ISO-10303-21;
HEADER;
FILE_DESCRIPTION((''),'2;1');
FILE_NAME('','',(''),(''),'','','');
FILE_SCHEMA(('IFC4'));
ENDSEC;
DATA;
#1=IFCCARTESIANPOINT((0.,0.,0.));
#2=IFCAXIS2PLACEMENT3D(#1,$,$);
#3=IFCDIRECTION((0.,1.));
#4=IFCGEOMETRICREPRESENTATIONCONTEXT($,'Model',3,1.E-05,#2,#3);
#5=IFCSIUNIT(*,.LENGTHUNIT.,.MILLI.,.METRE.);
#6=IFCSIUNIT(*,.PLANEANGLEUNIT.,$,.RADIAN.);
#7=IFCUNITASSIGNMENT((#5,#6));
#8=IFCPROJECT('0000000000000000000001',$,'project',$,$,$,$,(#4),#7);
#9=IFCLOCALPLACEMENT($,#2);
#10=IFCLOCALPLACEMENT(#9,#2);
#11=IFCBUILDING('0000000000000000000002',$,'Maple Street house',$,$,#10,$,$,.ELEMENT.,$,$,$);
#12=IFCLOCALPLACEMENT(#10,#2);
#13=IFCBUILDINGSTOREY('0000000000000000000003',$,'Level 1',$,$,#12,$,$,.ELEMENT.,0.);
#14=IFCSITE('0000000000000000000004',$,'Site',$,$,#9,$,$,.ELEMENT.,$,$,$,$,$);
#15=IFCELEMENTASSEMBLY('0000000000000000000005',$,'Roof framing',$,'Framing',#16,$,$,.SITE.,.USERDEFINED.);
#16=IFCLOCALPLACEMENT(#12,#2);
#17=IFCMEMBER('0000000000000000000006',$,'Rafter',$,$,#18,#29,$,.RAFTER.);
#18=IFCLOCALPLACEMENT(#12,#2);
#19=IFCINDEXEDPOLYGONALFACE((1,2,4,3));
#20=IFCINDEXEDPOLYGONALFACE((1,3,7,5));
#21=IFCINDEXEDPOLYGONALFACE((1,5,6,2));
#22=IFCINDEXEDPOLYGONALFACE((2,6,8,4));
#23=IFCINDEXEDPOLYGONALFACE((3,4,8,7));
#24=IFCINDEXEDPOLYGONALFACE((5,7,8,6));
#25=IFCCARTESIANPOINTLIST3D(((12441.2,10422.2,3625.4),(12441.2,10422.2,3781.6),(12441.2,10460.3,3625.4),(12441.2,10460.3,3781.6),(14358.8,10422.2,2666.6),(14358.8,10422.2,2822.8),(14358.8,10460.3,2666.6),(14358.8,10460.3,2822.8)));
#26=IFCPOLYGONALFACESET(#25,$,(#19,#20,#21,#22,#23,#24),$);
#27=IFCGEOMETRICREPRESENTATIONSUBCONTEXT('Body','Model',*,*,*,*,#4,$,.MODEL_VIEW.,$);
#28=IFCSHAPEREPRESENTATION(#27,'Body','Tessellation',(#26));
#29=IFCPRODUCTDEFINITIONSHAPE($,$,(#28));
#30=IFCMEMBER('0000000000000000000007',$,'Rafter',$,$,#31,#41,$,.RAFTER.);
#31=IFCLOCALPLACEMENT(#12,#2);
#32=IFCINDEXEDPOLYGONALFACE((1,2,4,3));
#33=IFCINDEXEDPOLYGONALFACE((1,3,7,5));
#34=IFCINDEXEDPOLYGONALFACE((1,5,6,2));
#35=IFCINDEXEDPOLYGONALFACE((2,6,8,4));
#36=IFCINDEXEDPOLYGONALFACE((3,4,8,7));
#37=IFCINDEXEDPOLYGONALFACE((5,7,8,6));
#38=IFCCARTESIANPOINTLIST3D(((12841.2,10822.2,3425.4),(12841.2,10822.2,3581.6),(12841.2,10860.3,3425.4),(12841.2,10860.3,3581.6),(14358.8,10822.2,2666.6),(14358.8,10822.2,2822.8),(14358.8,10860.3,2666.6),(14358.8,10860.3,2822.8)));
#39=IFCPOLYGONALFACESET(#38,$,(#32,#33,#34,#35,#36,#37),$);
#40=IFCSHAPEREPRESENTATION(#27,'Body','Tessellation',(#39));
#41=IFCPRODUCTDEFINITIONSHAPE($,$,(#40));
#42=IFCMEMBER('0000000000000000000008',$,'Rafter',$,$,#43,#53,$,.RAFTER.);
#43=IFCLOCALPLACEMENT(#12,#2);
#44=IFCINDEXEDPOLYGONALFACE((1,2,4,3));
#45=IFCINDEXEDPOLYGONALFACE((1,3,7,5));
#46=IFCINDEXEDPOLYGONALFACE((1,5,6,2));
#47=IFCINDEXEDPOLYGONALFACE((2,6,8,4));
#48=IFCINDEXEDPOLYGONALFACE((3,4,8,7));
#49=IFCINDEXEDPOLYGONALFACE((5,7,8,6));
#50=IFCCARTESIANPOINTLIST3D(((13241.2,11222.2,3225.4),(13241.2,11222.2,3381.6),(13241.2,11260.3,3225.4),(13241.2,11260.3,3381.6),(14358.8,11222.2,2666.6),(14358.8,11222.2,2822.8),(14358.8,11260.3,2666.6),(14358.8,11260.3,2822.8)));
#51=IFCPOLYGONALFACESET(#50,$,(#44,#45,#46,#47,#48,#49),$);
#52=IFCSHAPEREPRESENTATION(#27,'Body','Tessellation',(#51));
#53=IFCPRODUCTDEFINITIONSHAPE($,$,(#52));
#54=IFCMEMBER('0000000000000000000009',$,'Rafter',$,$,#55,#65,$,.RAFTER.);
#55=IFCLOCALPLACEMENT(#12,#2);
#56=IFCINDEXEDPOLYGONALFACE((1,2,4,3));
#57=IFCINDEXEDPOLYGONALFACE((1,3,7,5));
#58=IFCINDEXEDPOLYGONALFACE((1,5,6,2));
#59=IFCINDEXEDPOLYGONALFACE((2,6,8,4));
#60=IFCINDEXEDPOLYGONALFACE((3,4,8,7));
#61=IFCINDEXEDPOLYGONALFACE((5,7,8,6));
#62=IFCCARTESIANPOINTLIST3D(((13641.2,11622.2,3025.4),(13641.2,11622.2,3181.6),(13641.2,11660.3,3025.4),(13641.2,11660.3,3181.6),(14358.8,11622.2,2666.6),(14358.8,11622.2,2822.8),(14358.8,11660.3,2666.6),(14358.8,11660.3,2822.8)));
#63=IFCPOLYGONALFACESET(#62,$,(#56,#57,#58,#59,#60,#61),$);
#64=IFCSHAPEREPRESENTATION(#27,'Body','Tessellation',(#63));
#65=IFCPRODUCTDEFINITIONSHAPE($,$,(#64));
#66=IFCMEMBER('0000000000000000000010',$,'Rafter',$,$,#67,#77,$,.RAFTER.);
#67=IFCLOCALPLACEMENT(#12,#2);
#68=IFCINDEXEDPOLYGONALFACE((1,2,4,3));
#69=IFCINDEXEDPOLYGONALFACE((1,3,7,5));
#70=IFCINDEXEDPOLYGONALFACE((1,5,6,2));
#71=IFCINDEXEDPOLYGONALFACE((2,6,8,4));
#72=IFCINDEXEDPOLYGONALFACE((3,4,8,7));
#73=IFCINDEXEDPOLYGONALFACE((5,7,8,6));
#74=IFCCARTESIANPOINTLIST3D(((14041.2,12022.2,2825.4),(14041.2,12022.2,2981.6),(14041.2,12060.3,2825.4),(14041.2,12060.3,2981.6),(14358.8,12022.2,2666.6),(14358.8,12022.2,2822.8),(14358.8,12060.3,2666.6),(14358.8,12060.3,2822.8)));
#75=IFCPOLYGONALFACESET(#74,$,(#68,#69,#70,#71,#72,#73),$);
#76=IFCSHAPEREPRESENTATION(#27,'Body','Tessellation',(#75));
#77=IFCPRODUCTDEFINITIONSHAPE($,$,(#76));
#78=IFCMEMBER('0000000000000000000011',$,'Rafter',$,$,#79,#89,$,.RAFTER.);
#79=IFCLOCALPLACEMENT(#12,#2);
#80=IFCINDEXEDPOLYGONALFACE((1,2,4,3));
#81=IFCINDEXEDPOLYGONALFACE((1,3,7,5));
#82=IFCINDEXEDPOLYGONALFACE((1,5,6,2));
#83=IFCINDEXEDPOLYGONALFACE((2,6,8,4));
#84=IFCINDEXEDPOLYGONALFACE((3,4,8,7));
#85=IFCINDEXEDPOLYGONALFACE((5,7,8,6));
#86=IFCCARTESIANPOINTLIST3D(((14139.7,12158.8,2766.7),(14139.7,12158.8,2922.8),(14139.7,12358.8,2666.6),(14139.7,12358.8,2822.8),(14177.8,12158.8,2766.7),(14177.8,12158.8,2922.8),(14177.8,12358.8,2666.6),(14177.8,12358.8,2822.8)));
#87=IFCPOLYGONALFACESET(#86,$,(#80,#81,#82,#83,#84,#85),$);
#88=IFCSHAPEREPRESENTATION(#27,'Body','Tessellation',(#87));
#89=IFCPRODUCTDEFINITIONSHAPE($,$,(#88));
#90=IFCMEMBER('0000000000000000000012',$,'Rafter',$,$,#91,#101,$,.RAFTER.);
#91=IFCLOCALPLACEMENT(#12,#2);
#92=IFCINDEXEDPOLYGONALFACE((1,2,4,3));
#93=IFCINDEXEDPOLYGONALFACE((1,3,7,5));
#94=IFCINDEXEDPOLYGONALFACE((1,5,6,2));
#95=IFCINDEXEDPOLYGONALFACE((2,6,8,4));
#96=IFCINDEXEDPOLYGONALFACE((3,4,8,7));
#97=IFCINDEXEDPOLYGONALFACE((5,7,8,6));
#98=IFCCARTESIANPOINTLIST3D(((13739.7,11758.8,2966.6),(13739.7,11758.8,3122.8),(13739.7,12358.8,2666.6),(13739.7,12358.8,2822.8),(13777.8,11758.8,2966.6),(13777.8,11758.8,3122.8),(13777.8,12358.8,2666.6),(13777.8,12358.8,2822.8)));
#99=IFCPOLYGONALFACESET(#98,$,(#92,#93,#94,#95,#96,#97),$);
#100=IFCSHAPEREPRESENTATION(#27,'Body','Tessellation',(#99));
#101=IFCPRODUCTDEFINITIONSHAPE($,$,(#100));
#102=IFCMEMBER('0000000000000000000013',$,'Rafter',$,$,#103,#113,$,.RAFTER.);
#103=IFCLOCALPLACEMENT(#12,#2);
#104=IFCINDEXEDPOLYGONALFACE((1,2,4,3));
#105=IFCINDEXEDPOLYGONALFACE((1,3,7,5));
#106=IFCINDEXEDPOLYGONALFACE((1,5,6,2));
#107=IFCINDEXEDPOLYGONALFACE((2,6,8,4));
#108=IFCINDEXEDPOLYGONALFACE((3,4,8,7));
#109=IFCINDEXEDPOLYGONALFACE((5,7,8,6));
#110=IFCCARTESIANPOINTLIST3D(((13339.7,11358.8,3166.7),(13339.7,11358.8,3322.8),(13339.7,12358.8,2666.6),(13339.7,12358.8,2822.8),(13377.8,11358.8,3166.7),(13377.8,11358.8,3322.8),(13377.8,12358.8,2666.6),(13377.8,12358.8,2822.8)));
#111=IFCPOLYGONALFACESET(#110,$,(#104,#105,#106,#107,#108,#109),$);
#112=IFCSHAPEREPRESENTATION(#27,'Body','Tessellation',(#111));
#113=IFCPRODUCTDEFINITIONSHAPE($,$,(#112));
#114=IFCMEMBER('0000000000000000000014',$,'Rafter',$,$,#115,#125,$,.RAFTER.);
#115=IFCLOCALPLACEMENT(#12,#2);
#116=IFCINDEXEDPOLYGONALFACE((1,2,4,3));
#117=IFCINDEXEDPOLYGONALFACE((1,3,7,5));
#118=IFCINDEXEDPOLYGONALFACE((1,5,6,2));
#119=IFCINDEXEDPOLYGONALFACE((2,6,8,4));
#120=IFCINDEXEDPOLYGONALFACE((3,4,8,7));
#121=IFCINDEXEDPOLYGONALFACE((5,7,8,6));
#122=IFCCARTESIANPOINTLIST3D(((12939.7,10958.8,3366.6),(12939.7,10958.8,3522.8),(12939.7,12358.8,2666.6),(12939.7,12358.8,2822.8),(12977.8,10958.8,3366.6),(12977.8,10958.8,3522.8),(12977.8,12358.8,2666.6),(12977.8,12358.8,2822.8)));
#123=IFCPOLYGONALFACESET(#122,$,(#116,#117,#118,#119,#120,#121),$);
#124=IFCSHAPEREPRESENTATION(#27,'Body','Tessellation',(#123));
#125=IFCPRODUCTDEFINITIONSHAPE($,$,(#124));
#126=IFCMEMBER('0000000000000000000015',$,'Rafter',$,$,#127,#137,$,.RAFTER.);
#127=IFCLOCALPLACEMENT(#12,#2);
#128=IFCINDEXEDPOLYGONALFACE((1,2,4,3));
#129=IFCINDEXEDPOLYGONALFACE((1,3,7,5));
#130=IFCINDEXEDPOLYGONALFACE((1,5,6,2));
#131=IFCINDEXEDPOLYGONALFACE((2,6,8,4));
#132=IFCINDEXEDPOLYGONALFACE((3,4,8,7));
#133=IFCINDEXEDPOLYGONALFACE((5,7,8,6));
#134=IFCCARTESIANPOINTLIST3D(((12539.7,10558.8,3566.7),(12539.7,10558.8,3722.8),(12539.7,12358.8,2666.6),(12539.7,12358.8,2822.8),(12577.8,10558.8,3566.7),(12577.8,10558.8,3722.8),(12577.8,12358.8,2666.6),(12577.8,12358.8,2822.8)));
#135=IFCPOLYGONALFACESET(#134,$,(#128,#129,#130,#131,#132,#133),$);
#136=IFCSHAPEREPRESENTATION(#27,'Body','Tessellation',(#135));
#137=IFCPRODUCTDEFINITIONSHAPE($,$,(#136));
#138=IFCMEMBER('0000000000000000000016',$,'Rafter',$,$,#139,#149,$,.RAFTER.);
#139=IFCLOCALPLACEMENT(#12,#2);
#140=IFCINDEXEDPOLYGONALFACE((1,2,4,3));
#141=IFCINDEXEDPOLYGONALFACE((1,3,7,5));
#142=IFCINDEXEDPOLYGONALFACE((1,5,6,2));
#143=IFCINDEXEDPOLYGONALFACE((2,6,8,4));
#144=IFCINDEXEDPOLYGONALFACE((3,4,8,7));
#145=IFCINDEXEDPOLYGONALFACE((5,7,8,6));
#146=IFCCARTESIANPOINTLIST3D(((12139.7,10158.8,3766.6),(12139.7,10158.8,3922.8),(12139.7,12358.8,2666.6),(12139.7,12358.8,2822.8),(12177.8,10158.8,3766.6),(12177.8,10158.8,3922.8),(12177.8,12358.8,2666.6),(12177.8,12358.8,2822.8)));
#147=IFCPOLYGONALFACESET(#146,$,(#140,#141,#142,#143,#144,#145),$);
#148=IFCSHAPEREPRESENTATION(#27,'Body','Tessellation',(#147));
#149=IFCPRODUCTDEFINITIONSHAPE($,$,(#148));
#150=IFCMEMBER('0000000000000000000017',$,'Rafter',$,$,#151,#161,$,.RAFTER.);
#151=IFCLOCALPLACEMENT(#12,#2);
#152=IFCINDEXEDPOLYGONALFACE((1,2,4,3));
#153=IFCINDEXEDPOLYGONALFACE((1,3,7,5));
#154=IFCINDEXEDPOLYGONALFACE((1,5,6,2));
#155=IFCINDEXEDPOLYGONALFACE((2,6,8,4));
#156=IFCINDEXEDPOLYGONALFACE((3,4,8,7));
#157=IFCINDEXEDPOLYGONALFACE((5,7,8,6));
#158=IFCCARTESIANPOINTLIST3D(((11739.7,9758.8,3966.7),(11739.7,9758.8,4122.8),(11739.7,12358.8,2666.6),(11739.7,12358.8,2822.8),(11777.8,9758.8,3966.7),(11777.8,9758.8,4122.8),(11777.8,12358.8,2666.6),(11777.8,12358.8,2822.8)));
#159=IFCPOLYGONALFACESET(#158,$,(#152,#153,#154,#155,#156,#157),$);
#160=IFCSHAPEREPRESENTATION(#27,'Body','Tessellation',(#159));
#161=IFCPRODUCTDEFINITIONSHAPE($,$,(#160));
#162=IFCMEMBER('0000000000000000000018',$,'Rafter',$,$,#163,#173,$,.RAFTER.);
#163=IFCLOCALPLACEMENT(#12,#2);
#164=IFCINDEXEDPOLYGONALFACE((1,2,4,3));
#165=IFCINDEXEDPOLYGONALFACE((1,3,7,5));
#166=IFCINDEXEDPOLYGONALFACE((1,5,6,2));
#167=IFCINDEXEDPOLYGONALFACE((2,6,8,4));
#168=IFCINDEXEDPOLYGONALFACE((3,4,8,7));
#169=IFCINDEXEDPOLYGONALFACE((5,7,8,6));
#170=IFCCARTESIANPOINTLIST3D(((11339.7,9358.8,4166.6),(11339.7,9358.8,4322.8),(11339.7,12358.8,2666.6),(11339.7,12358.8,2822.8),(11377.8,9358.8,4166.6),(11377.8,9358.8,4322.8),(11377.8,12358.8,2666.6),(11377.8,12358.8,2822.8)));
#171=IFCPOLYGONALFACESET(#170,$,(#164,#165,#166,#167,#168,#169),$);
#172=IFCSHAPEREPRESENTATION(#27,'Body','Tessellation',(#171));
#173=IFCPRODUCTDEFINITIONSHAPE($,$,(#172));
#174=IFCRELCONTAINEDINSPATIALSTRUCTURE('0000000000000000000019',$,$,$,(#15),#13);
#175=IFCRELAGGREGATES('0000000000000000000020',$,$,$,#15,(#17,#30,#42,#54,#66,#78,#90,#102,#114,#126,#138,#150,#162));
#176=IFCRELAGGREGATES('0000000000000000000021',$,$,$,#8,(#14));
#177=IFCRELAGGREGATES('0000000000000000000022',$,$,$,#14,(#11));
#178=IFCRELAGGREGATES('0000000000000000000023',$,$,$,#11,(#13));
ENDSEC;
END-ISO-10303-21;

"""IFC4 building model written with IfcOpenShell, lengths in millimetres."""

from ifc_helpers import new_model, si_unit, direction, frame, origin, origin_with_axes, place, context, subcontext, project, spatial, polyline, outline, extrude, element, aggregate, save


model = new_model("IFC4")

# Units and contexts
model_context = context("Model", 3, precision=1e-05, world=origin(), true_north=direction((0.0, 1.0)))
body_context = subcontext(model_context, "Body", "Model", "MODEL_VIEW")
ifc_project = project(units=[si_unit("LENGTHUNIT", "METRE", prefix="MILLI"), si_unit("PLANEANGLEUNIT", "RADIAN")], contexts=[model_context])

# Site, building, storey
site_placement = place(None, origin())
site = spatial("IfcSite", under=ifc_project, at=site_placement, Name="Site", CompositionType="ELEMENT")
building_placement = place(site_placement, origin())
building = spatial("IfcBuilding", under=site, at=building_placement, Name="Maple Street house", CompositionType="ELEMENT")
storey_placement = place(building_placement, origin())
storey = spatial("IfcBuildingStorey", under=building, at=storey_placement, Name="Level 1", CompositionType="ELEMENT", Elevation=0.0)

# Element assembly, members
assembly_placement = place(storey_placement, origin_with_axes())
assembly = element("IfcElementAssembly", 1, at=assembly_placement, inside=storey, Name="Roof framing", ObjectType="Framing", AssemblyPlace="SITE", PredefinedType="USERDEFINED")
member_1_placement = place(storey_placement, origin_with_axes())
member_1 = element("IfcMember", 2, at=member_1_placement, Name="Rafter", PredefinedType="RAFTER", context=body_context, shape_type="SweptSolid", body=[
    extrude(outline(polyline([(0.0, 0.0), (38.1, 0.0), (38.1, 156.2), (0.0, 156.2), (0.0, 0.0)])), frame((14358.8, 10460.3, 2666.7), z_axis=(-1.0, 0.0, 0.0), x_axis=(0.0, -1.0, 0.0)), (0.0, 0.447214, 0.894427), 2143.9),
])
member_2_placement = place(storey_placement, origin_with_axes())
member_2 = element("IfcMember", 3, at=member_2_placement, Name="Rafter", PredefinedType="RAFTER", context=body_context, shape_type="SweptSolid", body=[
    extrude(outline(polyline([(0.0, 0.0), (38.1, 0.0), (38.1, 156.2), (0.0, 156.2), (0.0, 0.0)])), frame((14358.8, 10860.3, 2666.7), z_axis=(-1.0, 0.0, 0.0), x_axis=(0.0, -1.0, 0.0)), (0.0, 0.447214, 0.894427), 1696.7),
])
member_3_placement = place(storey_placement, origin_with_axes())
member_3 = element("IfcMember", 4, at=member_3_placement, Name="Rafter", PredefinedType="RAFTER", context=body_context, shape_type="SweptSolid", body=[
    extrude(outline(polyline([(0.0, 0.0), (38.1, 0.0), (38.1, 156.2), (0.0, 156.2), (0.0, 0.0)])), frame((14358.8, 11260.3, 2666.7), z_axis=(-1.0, 0.0, 0.0), x_axis=(0.0, -1.0, 0.0)), (0.0, 0.447214, 0.894427), 1249.5),
])
member_4_placement = place(storey_placement, origin_with_axes())
member_4 = element("IfcMember", 5, at=member_4_placement, Name="Rafter", PredefinedType="RAFTER", context=body_context, shape_type="SweptSolid", body=[
    extrude(outline(polyline([(0.0, 0.0), (38.1, 0.0), (38.1, 156.2), (0.0, 156.2), (0.0, 0.0)])), frame((14358.8, 11660.3, 2666.7), z_axis=(-1.0, 0.0, 0.0), x_axis=(0.0, -1.0, 0.0)), (0.0, 0.447214, 0.894427), 802.2),
])
member_5_placement = place(storey_placement, origin_with_axes())
member_5 = element("IfcMember", 6, at=member_5_placement, Name="Rafter", PredefinedType="RAFTER", context=body_context, shape_type="SweptSolid", body=[
    extrude(outline(polyline([(0.0, 0.0), (38.1, 0.0), (38.1, 156.2), (0.0, 156.2), (0.0, 0.0)])), frame((14358.8, 12060.3, 2666.7), z_axis=(-1.0, 0.0, 0.0), x_axis=(0.0, -1.0, 0.0)), (0.0, 0.447214, 0.894427), 355.0),
])
member_6_placement = place(storey_placement, origin_with_axes())
member_6 = element("IfcMember", 7, at=member_6_placement, Name="Rafter", PredefinedType="RAFTER", context=body_context, shape_type="SweptSolid", body=[
    extrude(outline(polyline([(0.0, 0.0), (38.1, 0.0), (38.1, 156.2), (0.0, 156.2), (0.0, 0.0)])), frame((14139.7, 12358.8, 2666.7), z_axis=(0.0, -1.0, 0.0), x_axis=(1.0, 0.0, 0.0)), (0.0, 0.447214, 0.894427), 223.6),
])
member_7_placement = place(storey_placement, origin_with_axes())
member_7 = element("IfcMember", 8, at=member_7_placement, Name="Rafter", PredefinedType="RAFTER", context=body_context, shape_type="SweptSolid", body=[
    extrude(outline(polyline([(0.0, 0.0), (38.1, 0.0), (38.1, 156.2), (0.0, 156.2), (0.0, 0.0)])), frame((13739.7, 12358.8, 2666.7), z_axis=(0.0, -1.0, 0.0), x_axis=(1.0, 0.0, 0.0)), (0.0, 0.447214, 0.894427), 670.8),
])
member_8_placement = place(storey_placement, origin_with_axes())
member_8 = element("IfcMember", 9, at=member_8_placement, Name="Rafter", PredefinedType="RAFTER", context=body_context, shape_type="SweptSolid", body=[
    extrude(outline(polyline([(0.0, 0.0), (38.1, 0.0), (38.1, 156.2), (0.0, 156.2), (0.0, 0.0)])), frame((13339.7, 12358.8, 2666.7), z_axis=(0.0, -1.0, 0.0), x_axis=(1.0, 0.0, 0.0)), (0.0, 0.447214, 0.894427), 1118.0),
])
member_9_placement = place(storey_placement, origin_with_axes())
member_9 = element("IfcMember", 10, at=member_9_placement, Name="Rafter", PredefinedType="RAFTER", context=body_context, shape_type="SweptSolid", body=[
    extrude(outline(polyline([(0.0, 0.0), (38.1, 0.0), (38.1, 156.2), (0.0, 156.2), (0.0, 0.0)])), frame((12939.7, 12358.8, 2666.7), z_axis=(0.0, -1.0, 0.0), x_axis=(1.0, 0.0, 0.0)), (0.0, 0.447214, 0.894427), 1565.2),
])
member_10_placement = place(storey_placement, origin_with_axes())
member_10 = element("IfcMember", 11, at=member_10_placement, Name="Rafter", PredefinedType="RAFTER", context=body_context, shape_type="SweptSolid", body=[
    extrude(outline(polyline([(0.0, 0.0), (38.1, 0.0), (38.1, 156.2), (0.0, 156.2), (0.0, 0.0)])), frame((12539.7, 12358.8, 2666.7), z_axis=(0.0, -1.0, 0.0), x_axis=(1.0, 0.0, 0.0)), (0.0, 0.447214, 0.894427), 2012.5),
])
member_11_placement = place(storey_placement, origin_with_axes())
member_11 = element("IfcMember", 12, at=member_11_placement, Name="Rafter", PredefinedType="RAFTER", context=body_context, shape_type="SweptSolid", body=[
    extrude(outline(polyline([(0.0, 0.0), (38.1, 0.0), (38.1, 156.2), (0.0, 156.2), (0.0, 0.0)])), frame((12139.7, 12358.8, 2666.7), z_axis=(0.0, -1.0, 0.0), x_axis=(1.0, 0.0, 0.0)), (0.0, 0.447214, 0.894427), 2459.7),
])
member_12_placement = place(storey_placement, origin_with_axes())
member_12 = element("IfcMember", 13, at=member_12_placement, Name="Rafter", PredefinedType="RAFTER", context=body_context, shape_type="SweptSolid", body=[
    extrude(outline(polyline([(0.0, 0.0), (38.1, 0.0), (38.1, 156.2), (0.0, 156.2), (0.0, 0.0)])), frame((11739.7, 12358.8, 2666.7), z_axis=(0.0, -1.0, 0.0), x_axis=(1.0, 0.0, 0.0)), (0.0, 0.447214, 0.894427), 2906.9),
])
member_13_placement = place(storey_placement, origin_with_axes())
member_13 = element("IfcMember", 14, at=member_13_placement, Name="Rafter", PredefinedType="RAFTER", context=body_context, shape_type="SweptSolid", body=[
    extrude(outline(polyline([(0.0, 0.0), (38.1, 0.0), (38.1, 156.2), (0.0, 156.2), (0.0, 0.0)])), frame((11339.7, 12358.8, 2666.7), z_axis=(0.0, -1.0, 0.0), x_axis=(1.0, 0.0, 0.0)), (0.0, 0.447214, 0.894427), 3354.1),
])
aggregate(assembly, [member_1, member_2, member_3, member_4, member_5, member_6, member_7, member_8, member_9, member_10, member_11, member_12, member_13])

save(model, "model.ifc")
